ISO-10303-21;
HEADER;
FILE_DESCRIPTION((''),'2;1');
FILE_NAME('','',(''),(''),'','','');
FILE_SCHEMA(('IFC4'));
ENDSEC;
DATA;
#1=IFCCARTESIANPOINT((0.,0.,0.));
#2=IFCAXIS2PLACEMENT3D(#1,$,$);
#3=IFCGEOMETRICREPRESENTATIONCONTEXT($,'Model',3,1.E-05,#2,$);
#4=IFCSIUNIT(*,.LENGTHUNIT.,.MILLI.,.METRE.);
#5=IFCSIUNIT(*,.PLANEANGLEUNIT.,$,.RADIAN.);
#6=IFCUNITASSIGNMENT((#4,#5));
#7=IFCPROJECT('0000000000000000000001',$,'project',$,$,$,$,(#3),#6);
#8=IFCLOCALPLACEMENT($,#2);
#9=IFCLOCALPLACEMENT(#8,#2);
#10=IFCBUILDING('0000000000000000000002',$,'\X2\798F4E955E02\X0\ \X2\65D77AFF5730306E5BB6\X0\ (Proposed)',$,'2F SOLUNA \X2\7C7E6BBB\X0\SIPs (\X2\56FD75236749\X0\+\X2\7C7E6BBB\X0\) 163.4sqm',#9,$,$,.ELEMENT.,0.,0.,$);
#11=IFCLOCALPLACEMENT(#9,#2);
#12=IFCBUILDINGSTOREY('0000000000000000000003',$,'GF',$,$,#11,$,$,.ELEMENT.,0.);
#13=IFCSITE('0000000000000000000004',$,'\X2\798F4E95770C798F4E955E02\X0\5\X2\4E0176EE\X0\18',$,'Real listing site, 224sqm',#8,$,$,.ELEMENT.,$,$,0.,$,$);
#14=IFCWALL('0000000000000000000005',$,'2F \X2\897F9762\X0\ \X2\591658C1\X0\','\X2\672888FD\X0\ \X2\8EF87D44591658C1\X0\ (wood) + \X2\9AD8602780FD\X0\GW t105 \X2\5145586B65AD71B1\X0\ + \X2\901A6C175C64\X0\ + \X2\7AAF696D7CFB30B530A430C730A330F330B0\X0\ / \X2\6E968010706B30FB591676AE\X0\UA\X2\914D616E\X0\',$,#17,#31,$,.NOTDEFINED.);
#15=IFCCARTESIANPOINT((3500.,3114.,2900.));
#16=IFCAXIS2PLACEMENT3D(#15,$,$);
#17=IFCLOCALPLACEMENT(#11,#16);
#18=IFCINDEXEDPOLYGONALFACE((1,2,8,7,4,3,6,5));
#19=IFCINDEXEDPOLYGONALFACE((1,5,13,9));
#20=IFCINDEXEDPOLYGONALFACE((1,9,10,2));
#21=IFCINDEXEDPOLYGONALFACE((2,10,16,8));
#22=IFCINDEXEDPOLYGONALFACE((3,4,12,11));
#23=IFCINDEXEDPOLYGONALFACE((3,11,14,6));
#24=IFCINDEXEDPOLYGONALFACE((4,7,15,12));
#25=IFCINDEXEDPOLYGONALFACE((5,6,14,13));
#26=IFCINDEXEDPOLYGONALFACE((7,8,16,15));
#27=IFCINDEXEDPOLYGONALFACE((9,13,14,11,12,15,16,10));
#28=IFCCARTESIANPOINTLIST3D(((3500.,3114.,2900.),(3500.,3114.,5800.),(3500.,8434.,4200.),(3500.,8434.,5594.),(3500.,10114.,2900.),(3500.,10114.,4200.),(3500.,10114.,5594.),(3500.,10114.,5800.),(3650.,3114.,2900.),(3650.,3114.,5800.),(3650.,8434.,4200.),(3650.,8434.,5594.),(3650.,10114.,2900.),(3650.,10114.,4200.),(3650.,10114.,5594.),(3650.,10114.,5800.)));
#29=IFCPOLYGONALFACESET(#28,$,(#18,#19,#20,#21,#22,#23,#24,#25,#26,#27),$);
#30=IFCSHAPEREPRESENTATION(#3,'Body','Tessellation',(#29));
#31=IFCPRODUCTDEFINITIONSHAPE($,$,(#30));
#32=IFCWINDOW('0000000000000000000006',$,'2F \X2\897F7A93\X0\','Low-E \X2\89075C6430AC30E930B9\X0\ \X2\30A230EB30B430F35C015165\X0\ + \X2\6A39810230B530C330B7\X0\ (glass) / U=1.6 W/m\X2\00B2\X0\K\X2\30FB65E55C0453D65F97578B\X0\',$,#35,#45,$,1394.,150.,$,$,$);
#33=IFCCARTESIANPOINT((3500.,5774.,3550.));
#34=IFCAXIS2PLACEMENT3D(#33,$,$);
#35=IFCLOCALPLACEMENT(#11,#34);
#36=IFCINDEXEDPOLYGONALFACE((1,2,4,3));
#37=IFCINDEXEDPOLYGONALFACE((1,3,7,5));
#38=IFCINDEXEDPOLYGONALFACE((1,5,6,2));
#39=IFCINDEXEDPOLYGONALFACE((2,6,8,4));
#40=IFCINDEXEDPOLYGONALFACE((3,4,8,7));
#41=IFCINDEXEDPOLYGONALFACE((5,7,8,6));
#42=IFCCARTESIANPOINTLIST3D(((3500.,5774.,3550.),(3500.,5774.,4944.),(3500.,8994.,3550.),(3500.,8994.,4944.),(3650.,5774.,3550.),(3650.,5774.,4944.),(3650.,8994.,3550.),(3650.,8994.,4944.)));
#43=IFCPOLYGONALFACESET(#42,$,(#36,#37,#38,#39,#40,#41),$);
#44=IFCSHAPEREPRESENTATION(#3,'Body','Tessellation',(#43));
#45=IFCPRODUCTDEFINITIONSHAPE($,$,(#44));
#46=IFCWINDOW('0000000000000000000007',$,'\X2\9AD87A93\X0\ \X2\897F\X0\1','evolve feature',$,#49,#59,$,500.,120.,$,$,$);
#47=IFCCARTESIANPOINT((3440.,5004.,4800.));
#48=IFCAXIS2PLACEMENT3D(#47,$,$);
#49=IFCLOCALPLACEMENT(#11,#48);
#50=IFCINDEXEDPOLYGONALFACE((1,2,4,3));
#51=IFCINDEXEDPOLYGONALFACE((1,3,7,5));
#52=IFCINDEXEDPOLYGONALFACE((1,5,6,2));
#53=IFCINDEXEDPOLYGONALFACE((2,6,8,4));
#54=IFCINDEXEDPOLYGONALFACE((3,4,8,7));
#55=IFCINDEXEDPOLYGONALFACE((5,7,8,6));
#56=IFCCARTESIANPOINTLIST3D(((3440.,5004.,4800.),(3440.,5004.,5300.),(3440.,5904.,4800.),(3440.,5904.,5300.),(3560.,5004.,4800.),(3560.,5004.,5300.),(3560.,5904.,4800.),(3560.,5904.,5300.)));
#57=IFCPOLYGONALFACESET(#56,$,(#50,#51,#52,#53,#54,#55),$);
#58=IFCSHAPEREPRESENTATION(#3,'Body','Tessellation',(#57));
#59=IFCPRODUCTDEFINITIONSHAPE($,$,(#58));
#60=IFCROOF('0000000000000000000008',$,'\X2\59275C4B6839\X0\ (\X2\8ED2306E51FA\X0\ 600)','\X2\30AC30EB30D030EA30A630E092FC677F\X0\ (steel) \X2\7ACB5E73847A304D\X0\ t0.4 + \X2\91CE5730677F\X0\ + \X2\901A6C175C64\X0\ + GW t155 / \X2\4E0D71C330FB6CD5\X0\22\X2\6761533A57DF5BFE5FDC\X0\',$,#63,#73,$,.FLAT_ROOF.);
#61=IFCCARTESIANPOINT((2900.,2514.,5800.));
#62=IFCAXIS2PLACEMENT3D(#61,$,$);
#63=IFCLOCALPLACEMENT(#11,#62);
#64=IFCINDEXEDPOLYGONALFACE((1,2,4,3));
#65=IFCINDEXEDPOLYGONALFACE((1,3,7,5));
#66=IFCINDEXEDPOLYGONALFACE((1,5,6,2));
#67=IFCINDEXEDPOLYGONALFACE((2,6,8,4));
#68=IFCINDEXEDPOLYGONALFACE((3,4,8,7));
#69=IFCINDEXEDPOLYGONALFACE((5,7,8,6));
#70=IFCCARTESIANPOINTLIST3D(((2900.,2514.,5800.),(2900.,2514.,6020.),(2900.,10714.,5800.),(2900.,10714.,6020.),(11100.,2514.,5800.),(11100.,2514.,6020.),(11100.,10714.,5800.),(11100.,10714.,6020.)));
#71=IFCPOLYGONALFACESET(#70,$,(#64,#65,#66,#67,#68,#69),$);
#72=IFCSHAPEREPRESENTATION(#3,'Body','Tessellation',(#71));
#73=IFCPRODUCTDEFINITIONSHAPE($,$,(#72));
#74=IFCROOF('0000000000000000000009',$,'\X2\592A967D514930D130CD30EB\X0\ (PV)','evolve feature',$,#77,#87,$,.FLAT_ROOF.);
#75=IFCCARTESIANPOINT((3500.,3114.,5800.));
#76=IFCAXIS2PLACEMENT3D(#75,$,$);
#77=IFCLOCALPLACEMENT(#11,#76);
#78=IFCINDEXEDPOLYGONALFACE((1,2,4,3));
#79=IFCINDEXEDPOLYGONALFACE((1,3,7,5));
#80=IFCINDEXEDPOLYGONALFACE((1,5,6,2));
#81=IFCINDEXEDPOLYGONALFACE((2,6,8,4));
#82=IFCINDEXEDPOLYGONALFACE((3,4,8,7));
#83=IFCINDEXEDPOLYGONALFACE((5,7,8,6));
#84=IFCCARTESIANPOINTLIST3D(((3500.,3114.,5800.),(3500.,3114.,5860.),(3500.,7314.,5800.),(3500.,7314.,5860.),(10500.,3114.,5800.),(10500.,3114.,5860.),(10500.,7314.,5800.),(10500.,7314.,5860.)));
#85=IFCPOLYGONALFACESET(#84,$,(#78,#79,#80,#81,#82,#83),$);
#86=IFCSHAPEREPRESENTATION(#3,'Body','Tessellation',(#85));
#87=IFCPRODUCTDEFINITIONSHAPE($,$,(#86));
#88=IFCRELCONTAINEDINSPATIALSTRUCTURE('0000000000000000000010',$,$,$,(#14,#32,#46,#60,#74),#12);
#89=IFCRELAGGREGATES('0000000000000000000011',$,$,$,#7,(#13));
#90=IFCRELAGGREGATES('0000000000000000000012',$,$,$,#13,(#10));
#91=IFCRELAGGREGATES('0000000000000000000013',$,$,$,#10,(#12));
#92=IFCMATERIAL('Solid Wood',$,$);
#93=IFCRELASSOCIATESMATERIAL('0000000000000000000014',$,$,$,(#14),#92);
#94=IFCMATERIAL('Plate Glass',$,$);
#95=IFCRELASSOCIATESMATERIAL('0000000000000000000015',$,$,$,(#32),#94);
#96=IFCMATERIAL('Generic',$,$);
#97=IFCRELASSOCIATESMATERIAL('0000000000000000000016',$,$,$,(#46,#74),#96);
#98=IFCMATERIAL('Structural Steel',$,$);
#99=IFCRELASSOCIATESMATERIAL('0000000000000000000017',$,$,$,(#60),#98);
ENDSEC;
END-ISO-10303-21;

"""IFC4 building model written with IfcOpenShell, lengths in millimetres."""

from ifc_helpers import new_model, si_unit, frame, frame_2d, origin, place, context, project, spatial, rectangle, extrude, material, element, fill, save


model = new_model("IFC4")

# Units and contexts
model_context = context("Model", 3, precision=1e-05, world=origin())
ifc_project = project(units=[si_unit("LENGTHUNIT", "METRE", prefix="MILLI"), si_unit("PLANEANGLEUNIT", "RADIAN")], contexts=[model_context])

# Site, building, storey
site_placement = place(None, origin())
site = spatial("IfcSite", under=ifc_project, at=site_placement, Name="福井県福井市5丁目18", ObjectType="Real listing site, 224sqm", CompositionType="ELEMENT", RefElevation=0.0)
building_placement = place(site_placement, origin())
building = spatial("IfcBuilding", under=site, at=building_placement, Name="福井市 旗竿地の家 (Proposed)", ObjectType="2F SOLUNA 籾殻SIPs (国産杉+籾殻) 163.4sqm", CompositionType="ELEMENT", ElevationOfRefHeight=0.0, ElevationOfTerrain=0.0)
storey_placement = place(building_placement, origin())
storey = spatial("IfcBuildingStorey", under=building, at=storey_placement, Name="GF", CompositionType="ELEMENT", Elevation=0.0)

# Shared definitions
ifc_material_1 = material(Name="Solid Wood")
ifc_material_2 = material(Name="Generic")

# Shared definitions
ifc_material_3 = material(Name="Plate Glass")

# Wall, openings, windows
wall_1_placement = place(storey_placement, frame((3500.0, 3114.0, 2900.0)))
wall_1 = element("IfcWall", 1, at=wall_1_placement, inside=storey, material=ifc_material_1, Name="2F 西面 外壁", Description="木製 軸組外壁 (wood) + 高性能GW t105 充填断熱 + 通気層 + 窯業系サイディング / 準耐火・外皮UA配慮", PredefinedType="NOTDEFINED", context=model_context, shape_type="SweptSolid", body=[
    extrude(rectangle(XDim=150.0, YDim=7000.0, at=frame_2d((75.0, 3500.0))), frame((3500.0, 3114.0, 2900.0)), (0.0, 0.0, 1.0), 2900.0),
])
opening_1_placement = place(storey_placement, frame((3500.0, 5774.0, 3550.0)))
opening_1 = element("IfcOpeningElement", 2, at=opening_1_placement, cuts=wall_1, PredefinedType="NOTDEFINED", context=model_context, shape_type="SweptSolid", body=[
    extrude(rectangle(XDim=150.0, YDim=3220.0, at=frame_2d((75.0, 1610.0))), frame((3500.0, 5774.0, 3550.0)), (0.0, 0.0, 1.0), 1394.0),
])
opening_2_placement = place(storey_placement, frame((3440.0, 5004.0, 4800.0)))
opening_2 = element("IfcOpeningElement", 3, at=opening_2_placement, cuts=wall_1, PredefinedType="NOTDEFINED", context=model_context, shape_type="SweptSolid", body=[
    extrude(rectangle(XDim=120.0, YDim=900.0, at=frame_2d((60.0, 450.0))), frame((3440.0, 5004.0, 4800.0)), (0.0, 0.0, 1.0), 500.0),
])
window_1_placement = place(storey_placement, frame((3500.0, 5774.0, 3550.0)))
window_1 = element("IfcWindow", 4, at=window_1_placement, inside=storey, material=ifc_material_3, Name="2F 西窓", Description="Low-E 複層ガラス アルゴン封入 + 樹脂サッシ (glass) / U=1.6 W/m²K・日射取得型", OverallHeight=1394.0, OverallWidth=150.0, context=model_context, shape_type="SweptSolid", body=[
    extrude(rectangle(XDim=150.0, YDim=3220.0, at=frame_2d((75.0, 1610.0))), frame((3500.0, 5774.0, 3550.0)), (0.0, 0.0, 1.0), 1394.0),
])
fill(opening_1, window_1)
window_2_placement = place(storey_placement, frame((3440.0, 5004.0, 4800.0)))
window_2 = element("IfcWindow", 5, at=window_2_placement, inside=storey, material=ifc_material_2, Name="高窓 西1", Description="evolve feature", OverallHeight=500.0, OverallWidth=120.0, context=model_context, shape_type="SweptSolid", body=[
    extrude(rectangle(XDim=120.0, YDim=900.0, at=frame_2d((60.0, 450.0))), frame((3440.0, 5004.0, 4800.0)), (0.0, 0.0, 1.0), 500.0),
])
fill(opening_2, window_2)

# Roofs
ifc_material_4 = material(Name="Structural Steel")
roof_1_placement = place(storey_placement, frame((2900.0, 2514.0, 5800.0)))
element("IfcRoof", 6, at=roof_1_placement, inside=storey, material=ifc_material_4, Name="大屋根 (軒の出 600)", Description="ガルバリウム鋼板 (steel) 立平葺き t0.4 + 野地板 + 通気層 + GW t155 / 不燃・法22条区域対応", PredefinedType="FLAT_ROOF", context=model_context, shape_type="SweptSolid", body=[
    extrude(rectangle(XDim=8200.0, YDim=8200.0, at=frame_2d((4100.0, 4100.0))), frame((2900.0, 2514.0, 5800.0)), (0.0, 0.0, 1.0), 220.0),
])
roof_2_placement = place(storey_placement, frame((3500.0, 3114.0, 5800.0)))
element("IfcRoof", 7, at=roof_2_placement, inside=storey, material=ifc_material_2, Name="太陽光パネル (PV)", Description="evolve feature", PredefinedType="FLAT_ROOF", context=model_context, shape_type="SweptSolid", body=[
    extrude(rectangle(XDim=7000.0, YDim=4200.0, at=frame_2d((3500.0, 2100.0))), frame((3500.0, 3114.0, 5800.0)), (0.0, 0.0, 1.0), 60.0),
])

save(model, "model.ifc")
